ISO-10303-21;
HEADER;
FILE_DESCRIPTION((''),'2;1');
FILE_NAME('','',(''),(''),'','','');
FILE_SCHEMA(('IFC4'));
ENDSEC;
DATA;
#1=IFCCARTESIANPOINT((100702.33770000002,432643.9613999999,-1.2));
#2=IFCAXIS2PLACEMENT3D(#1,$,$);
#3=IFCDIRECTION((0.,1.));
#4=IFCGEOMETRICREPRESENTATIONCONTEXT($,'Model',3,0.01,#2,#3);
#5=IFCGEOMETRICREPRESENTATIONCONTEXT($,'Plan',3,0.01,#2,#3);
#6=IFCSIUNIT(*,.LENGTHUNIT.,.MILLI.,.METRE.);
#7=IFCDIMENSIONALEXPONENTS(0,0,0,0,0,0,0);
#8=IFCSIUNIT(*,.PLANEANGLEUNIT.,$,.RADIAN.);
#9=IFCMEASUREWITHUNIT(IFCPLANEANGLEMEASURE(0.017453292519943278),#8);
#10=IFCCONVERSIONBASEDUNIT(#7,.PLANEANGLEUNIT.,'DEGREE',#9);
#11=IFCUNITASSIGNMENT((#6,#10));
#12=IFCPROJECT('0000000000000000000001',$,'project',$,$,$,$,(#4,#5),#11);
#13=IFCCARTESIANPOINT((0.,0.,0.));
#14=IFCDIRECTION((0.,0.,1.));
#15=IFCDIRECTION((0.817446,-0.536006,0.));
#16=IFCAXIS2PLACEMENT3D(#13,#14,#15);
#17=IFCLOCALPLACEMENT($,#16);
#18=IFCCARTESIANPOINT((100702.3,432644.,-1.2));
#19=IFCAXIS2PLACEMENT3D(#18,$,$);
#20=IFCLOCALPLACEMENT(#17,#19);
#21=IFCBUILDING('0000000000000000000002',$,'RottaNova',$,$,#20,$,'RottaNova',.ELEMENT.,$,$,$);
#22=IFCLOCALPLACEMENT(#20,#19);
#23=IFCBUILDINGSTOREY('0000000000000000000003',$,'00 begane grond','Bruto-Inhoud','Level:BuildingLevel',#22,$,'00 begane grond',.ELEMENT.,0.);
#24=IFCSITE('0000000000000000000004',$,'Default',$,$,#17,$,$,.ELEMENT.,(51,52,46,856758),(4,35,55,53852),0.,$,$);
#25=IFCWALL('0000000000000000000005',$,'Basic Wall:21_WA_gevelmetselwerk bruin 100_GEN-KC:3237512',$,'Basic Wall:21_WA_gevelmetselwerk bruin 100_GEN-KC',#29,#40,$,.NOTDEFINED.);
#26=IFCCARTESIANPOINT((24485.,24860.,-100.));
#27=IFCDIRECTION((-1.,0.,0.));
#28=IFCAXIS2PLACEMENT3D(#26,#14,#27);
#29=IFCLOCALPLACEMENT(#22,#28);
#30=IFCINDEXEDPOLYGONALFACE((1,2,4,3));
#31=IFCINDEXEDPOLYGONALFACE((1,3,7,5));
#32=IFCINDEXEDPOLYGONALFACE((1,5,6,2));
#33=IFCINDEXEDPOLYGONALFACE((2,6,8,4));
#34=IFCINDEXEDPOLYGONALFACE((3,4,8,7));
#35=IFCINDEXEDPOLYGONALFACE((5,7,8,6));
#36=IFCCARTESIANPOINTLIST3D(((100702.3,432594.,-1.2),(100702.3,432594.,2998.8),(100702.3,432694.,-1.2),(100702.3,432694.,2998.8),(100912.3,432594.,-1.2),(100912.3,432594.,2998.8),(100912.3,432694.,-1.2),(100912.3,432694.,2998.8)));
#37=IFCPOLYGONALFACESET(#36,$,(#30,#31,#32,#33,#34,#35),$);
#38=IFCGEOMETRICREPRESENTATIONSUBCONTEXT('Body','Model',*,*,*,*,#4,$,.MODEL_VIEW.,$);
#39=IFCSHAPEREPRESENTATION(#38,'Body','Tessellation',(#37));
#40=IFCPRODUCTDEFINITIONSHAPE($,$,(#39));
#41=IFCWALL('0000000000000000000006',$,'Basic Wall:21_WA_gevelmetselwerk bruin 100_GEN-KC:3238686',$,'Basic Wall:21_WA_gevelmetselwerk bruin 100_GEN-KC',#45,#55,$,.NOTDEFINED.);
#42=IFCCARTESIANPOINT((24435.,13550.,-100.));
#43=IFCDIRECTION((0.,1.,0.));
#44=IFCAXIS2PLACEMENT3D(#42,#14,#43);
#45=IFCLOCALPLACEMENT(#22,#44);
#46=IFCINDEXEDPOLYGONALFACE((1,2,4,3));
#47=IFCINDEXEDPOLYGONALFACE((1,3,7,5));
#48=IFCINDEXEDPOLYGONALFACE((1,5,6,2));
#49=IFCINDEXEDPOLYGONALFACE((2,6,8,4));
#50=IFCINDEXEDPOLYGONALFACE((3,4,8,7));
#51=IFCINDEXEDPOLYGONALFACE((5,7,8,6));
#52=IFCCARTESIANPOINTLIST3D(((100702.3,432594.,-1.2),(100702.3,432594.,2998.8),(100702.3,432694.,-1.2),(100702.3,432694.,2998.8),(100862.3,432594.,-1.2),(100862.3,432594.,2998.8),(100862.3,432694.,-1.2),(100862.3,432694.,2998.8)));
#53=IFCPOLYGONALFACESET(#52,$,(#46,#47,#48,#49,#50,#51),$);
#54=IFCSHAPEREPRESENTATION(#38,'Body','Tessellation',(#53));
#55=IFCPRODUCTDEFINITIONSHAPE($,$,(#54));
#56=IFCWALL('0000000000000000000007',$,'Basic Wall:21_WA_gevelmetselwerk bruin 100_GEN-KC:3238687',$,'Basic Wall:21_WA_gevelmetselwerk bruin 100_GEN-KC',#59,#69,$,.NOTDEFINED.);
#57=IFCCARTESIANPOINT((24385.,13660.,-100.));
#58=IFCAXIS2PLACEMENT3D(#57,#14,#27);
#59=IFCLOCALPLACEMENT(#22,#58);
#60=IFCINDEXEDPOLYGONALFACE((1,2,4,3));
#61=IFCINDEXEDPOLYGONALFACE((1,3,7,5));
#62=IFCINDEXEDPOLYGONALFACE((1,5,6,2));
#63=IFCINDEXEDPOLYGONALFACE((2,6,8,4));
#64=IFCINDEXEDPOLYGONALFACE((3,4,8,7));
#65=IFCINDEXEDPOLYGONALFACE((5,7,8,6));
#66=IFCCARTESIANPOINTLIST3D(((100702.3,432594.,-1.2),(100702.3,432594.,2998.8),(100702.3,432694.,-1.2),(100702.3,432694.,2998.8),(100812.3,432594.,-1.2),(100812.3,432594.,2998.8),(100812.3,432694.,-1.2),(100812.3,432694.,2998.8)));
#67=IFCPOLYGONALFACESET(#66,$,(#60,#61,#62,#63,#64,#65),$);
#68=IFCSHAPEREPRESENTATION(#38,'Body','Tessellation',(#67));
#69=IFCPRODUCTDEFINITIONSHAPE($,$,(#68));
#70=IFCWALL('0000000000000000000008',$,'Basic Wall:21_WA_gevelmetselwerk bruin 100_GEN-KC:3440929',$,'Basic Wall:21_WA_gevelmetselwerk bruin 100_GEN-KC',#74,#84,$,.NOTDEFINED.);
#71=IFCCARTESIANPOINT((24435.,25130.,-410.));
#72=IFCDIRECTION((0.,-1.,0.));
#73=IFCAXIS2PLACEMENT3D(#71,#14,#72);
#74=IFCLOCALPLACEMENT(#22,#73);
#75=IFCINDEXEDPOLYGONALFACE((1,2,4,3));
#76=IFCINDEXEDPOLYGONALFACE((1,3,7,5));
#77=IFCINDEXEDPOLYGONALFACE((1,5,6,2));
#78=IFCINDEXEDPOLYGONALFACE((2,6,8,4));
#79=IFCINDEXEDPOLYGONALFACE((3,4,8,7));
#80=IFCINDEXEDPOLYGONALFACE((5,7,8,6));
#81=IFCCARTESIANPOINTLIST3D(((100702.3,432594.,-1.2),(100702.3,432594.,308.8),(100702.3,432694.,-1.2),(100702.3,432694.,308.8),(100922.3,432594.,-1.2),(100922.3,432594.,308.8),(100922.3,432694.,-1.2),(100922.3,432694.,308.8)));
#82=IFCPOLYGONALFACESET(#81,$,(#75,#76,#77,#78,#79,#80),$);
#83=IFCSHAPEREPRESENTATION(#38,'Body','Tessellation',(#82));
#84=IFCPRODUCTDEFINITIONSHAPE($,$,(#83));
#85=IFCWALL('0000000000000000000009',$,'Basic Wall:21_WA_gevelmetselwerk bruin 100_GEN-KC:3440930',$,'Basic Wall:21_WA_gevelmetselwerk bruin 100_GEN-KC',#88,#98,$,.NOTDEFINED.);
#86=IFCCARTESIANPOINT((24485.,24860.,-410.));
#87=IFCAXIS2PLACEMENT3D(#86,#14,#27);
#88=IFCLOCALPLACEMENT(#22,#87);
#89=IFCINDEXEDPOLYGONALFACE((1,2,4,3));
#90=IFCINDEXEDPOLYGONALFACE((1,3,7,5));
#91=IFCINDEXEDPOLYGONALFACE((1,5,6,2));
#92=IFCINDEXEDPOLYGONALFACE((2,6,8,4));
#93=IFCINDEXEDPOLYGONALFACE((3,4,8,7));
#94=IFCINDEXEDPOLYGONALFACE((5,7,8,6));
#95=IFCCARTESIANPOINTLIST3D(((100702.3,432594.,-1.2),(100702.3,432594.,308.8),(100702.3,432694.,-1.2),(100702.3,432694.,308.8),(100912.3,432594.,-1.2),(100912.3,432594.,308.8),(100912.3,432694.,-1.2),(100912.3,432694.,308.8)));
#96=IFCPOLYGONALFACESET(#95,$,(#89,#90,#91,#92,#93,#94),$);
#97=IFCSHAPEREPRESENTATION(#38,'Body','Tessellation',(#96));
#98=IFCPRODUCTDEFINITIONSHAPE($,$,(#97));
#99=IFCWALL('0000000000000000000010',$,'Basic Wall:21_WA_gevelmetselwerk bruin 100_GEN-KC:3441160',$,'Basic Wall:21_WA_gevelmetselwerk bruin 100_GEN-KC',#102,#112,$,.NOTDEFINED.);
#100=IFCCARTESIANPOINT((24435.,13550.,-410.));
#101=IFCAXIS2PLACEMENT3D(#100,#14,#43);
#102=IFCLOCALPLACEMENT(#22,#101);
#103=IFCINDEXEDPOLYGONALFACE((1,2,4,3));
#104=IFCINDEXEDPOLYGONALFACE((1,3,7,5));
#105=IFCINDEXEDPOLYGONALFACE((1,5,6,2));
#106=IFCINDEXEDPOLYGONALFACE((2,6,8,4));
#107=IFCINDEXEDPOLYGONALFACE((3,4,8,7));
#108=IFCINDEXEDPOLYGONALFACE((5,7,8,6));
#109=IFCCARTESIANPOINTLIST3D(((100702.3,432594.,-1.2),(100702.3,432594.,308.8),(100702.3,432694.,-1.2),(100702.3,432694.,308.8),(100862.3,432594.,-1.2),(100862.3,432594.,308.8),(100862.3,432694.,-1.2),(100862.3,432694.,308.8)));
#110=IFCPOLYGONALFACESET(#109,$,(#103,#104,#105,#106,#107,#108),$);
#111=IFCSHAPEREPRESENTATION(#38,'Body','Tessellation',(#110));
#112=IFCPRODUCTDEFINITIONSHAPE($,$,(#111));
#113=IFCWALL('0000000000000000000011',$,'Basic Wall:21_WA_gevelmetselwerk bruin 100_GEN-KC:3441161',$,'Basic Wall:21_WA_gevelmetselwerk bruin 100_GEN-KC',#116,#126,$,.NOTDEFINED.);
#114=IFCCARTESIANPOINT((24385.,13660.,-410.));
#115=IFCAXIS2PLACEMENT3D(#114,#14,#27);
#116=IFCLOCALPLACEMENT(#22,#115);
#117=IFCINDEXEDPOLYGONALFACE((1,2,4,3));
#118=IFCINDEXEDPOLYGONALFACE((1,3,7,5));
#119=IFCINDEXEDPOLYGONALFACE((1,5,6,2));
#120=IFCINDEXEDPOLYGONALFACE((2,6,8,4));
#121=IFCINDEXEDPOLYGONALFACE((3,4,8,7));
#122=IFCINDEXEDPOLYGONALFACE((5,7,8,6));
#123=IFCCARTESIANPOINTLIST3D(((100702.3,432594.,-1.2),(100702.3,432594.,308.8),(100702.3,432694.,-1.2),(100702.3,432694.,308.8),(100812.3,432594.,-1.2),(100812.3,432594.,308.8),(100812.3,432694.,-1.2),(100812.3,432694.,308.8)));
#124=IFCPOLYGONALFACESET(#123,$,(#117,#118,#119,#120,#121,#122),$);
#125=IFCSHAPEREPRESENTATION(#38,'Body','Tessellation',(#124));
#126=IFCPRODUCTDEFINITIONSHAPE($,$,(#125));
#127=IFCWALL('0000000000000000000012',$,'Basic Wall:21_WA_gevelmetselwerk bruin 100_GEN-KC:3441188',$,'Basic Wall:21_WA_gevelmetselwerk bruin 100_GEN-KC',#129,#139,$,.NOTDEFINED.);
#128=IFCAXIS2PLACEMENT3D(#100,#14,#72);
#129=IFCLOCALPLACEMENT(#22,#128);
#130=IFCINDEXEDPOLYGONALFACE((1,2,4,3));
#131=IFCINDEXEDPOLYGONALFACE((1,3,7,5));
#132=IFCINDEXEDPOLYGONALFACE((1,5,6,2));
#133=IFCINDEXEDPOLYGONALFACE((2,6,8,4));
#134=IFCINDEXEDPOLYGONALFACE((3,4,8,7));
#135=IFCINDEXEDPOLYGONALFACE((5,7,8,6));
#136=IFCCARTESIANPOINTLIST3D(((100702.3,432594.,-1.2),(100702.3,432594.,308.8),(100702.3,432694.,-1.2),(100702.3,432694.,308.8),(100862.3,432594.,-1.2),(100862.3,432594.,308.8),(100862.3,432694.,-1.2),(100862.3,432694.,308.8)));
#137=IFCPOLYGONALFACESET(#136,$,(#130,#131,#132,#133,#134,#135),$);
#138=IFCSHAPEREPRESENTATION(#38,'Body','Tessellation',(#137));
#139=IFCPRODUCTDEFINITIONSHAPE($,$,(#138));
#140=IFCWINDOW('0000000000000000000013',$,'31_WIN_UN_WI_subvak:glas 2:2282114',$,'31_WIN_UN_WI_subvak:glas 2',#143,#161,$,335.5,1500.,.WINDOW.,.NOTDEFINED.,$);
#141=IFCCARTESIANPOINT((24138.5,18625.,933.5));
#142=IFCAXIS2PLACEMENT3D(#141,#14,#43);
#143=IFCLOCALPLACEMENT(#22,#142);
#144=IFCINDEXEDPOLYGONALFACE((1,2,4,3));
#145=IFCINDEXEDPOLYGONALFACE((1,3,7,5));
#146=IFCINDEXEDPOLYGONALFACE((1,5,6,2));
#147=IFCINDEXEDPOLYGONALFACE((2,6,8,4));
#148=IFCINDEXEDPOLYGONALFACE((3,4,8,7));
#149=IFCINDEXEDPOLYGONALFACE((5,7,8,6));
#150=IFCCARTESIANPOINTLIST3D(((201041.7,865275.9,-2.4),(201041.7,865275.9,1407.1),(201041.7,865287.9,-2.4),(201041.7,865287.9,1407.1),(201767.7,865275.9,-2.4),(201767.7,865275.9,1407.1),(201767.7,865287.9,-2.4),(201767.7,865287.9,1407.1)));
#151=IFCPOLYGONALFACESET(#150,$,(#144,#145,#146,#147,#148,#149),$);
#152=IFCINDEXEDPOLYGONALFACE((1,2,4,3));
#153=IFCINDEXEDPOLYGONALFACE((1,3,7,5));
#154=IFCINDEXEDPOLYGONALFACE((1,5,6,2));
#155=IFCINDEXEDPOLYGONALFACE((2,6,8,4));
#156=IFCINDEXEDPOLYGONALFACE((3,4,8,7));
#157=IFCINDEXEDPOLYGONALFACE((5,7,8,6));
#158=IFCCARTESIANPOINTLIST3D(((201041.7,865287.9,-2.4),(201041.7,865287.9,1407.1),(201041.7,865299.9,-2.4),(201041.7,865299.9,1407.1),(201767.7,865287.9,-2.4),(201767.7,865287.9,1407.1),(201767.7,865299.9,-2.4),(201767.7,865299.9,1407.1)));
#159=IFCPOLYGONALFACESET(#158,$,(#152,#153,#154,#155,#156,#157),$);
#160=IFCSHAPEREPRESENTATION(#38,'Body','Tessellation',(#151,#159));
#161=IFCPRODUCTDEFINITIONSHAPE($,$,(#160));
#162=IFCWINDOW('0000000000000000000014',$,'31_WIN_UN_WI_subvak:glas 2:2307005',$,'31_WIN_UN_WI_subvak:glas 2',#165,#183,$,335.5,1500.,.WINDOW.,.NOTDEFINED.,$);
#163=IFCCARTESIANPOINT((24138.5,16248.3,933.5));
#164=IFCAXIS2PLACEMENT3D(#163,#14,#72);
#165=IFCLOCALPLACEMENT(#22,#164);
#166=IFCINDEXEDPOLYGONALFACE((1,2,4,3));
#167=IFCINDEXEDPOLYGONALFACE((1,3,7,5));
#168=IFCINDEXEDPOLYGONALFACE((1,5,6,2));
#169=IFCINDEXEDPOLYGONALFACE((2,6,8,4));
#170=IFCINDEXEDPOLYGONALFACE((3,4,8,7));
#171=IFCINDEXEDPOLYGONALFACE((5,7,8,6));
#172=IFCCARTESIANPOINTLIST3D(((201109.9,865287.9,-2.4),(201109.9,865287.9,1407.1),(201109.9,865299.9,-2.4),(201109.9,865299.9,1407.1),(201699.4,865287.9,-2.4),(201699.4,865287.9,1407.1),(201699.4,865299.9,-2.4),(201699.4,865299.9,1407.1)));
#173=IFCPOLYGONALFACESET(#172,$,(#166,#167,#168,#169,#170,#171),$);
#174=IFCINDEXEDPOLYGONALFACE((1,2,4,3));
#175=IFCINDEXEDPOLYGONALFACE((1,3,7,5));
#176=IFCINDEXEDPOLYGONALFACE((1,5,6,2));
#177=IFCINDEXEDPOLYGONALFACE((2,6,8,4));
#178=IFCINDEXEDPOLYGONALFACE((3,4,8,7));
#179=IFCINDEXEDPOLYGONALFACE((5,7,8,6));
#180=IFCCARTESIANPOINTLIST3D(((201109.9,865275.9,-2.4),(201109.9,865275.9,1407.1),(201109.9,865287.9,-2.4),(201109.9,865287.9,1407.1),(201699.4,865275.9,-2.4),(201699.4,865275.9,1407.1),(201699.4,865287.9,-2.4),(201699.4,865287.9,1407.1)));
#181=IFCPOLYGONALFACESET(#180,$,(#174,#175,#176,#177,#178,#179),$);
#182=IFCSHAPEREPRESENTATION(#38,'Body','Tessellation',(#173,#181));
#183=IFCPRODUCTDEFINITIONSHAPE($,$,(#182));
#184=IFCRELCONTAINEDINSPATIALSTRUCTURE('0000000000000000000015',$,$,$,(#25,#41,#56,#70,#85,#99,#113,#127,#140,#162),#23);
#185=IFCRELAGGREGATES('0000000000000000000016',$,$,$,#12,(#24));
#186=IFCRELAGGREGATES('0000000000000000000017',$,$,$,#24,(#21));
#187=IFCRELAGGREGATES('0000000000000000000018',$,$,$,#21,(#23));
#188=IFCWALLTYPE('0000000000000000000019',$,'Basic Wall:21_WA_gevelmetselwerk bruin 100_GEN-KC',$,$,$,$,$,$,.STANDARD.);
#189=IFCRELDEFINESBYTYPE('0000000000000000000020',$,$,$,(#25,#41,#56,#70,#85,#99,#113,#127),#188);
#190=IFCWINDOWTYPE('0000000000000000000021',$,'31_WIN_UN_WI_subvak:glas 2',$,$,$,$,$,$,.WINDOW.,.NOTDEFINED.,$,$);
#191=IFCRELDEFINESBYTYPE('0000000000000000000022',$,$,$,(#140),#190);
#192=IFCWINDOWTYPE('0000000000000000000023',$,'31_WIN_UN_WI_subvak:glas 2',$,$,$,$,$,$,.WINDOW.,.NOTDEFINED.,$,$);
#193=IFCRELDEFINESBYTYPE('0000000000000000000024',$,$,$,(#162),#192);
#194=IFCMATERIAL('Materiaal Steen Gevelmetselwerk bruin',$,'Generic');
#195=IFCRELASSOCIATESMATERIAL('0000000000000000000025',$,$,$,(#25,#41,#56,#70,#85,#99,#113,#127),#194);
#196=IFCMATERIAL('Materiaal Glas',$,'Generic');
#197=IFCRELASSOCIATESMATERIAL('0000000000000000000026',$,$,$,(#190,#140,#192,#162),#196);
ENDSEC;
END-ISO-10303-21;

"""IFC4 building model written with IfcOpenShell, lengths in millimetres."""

from ifc_helpers import new_model, entity, si_unit, converted_unit, direction, frame, place, context, subcontext, project, spatial, indexed_curve, outline, extrude, source, transform, mapped, material, type_object, type_shapes, element, save


model = new_model("IFC4")

# Units and contexts
model_context = context("Model", 3, precision=0.01, world=frame((100702.33770000002, 432643.9613999999, -1.2)), true_north=direction((0.0, 1.0)))
plan_context = context("Plan", 3, precision=0.01, world=frame((100702.33770000002, 432643.9613999999, -1.2)), true_north=direction((0.0, 1.0)))
body_context = subcontext(model_context, "Body", "Model", "MODEL_VIEW")
ifc_project = project(units=[si_unit("LENGTHUNIT", "METRE", prefix="MILLI"), converted_unit("PLANEANGLEUNIT", "DEGREE", entity("IfcPlaneAngleMeasure", 0.017453292519943278), si_unit("PLANEANGLEUNIT", "RADIAN"), dimensions=[0, 0, 0, 0, 0, 0, 0])], contexts=[model_context, plan_context])

# Site, building, storey
site_placement = place(None, frame((0.0, 0.0, 0.0), z_axis=(0.0, 0.0, 1.0), x_axis=(0.817446, -0.536006, 0.0)))
site = spatial("IfcSite", under=ifc_project, at=site_placement, Name="Default", CompositionType="ELEMENT", RefLatitude=(51, 52, 46, 856758), RefLongitude=(4, 35, 55, 53852), RefElevation=0.0)
building_placement = place(site_placement, frame((100702.3, 432644.0, -1.2)))
building = spatial("IfcBuilding", under=site, at=building_placement, Name="RottaNova", LongName="RottaNova", CompositionType="ELEMENT")
storey_placement = place(building_placement, frame((100702.3, 432644.0, -1.2)))
storey = spatial("IfcBuildingStorey", under=building, at=storey_placement, Name="00 begane grond", Description="Bruto-Inhoud", ObjectType="Level:BuildingLevel", LongName="00 begane grond", CompositionType="ELEMENT", Elevation=0.0)

# Walls
ifc_material_1 = material(Name="Materiaal Steen Gevelmetselwerk bruin", Category="Generic")
wall_type_1 = type_object("IfcWallType", Name="Basic Wall:21_WA_gevelmetselwerk bruin 100_GEN-KC", PredefinedType="STANDARD")
wall_1_placement = place(storey_placement, frame((24485.0, 24860.0, -100.0), z_axis=(0.0, 0.0, 1.0), x_axis=(-1.0, 0.0, 0.0)))
element("IfcWall", 1, at=wall_1_placement, inside=storey, type_object=wall_type_1, material=ifc_material_1, Name="Basic Wall:21_WA_gevelmetselwerk bruin 100_GEN-KC:3237512", ObjectType="Basic Wall:21_WA_gevelmetselwerk bruin 100_GEN-KC", PredefinedType="NOTDEFINED", context=body_context, shape_type="SweptSolid", body=[
    extrude(outline(indexed_curve([(210.0, 50.0), (0.0, 50.0), (0.0, -50.0), (210.0, -50.0), (210.0, 50.0)], self_intersect=False)), frame((100702.3, 432644.0, -1.2)), (0.0, 0.0, 1.0), 3000.0),
])
wall_2_placement = place(storey_placement, frame((24435.0, 13550.0, -100.0), z_axis=(0.0, 0.0, 1.0), x_axis=(0.0, 1.0, 0.0)))
element("IfcWall", 2, at=wall_2_placement, inside=storey, type_object=wall_type_1, material=ifc_material_1, Name="Basic Wall:21_WA_gevelmetselwerk bruin 100_GEN-KC:3238686", ObjectType="Basic Wall:21_WA_gevelmetselwerk bruin 100_GEN-KC", PredefinedType="NOTDEFINED", context=body_context, shape_type="SweptSolid", body=[
    extrude(outline(indexed_curve([(160.0, 50.0), (0.0, 50.0), (0.0, -50.0), (160.0, -50.0), (160.0, 50.0)], self_intersect=False)), frame((100702.3, 432644.0, -1.2)), (0.0, 0.0, 1.0), 3000.0),
])
wall_3_placement = place(storey_placement, frame((24385.0, 13660.0, -100.0), z_axis=(0.0, 0.0, 1.0), x_axis=(-1.0, 0.0, 0.0)))
element("IfcWall", 3, at=wall_3_placement, inside=storey, type_object=wall_type_1, material=ifc_material_1, Name="Basic Wall:21_WA_gevelmetselwerk bruin 100_GEN-KC:3238687", ObjectType="Basic Wall:21_WA_gevelmetselwerk bruin 100_GEN-KC", PredefinedType="NOTDEFINED", context=body_context, shape_type="SweptSolid", body=[
    extrude(outline(indexed_curve([(110.0, 50.0), (0.0, 50.0), (0.0, -50.0), (110.0, -50.0), (110.0, 50.0)], self_intersect=False)), frame((100702.3, 432644.0, -1.2)), (0.0, 0.0, 1.0), 3000.0),
])
wall_4_placement = place(storey_placement, frame((24435.0, 25130.0, -410.0), z_axis=(0.0, 0.0, 1.0), x_axis=(0.0, -1.0, 0.0)))
element("IfcWall", 4, at=wall_4_placement, inside=storey, type_object=wall_type_1, material=ifc_material_1, Name="Basic Wall:21_WA_gevelmetselwerk bruin 100_GEN-KC:3440929", ObjectType="Basic Wall:21_WA_gevelmetselwerk bruin 100_GEN-KC", PredefinedType="NOTDEFINED", context=body_context, shape_type="SweptSolid", body=[
    extrude(outline(indexed_curve([(220.0, 50.0), (0.0, 50.0), (0.0, -50.0), (220.0, -50.0), (220.0, 50.0)], self_intersect=False)), frame((100702.3, 432644.0, -1.2)), (0.0, 0.0, 1.0), 310.0),
])
wall_5_placement = place(storey_placement, frame((24485.0, 24860.0, -410.0), z_axis=(0.0, 0.0, 1.0), x_axis=(-1.0, 0.0, 0.0)))
element("IfcWall", 5, at=wall_5_placement, inside=storey, type_object=wall_type_1, material=ifc_material_1, Name="Basic Wall:21_WA_gevelmetselwerk bruin 100_GEN-KC:3440930", ObjectType="Basic Wall:21_WA_gevelmetselwerk bruin 100_GEN-KC", PredefinedType="NOTDEFINED", context=body_context, shape_type="SweptSolid", body=[
    extrude(outline(indexed_curve([(210.0, 50.0), (0.0, 50.0), (0.0, -50.0), (210.0, -50.0), (210.0, 50.0)], self_intersect=False)), frame((100702.3, 432644.0, -1.2)), (0.0, 0.0, 1.0), 310.0),
])
wall_6_placement = place(storey_placement, frame((24435.0, 13550.0, -410.0), z_axis=(0.0, 0.0, 1.0), x_axis=(0.0, 1.0, 0.0)))
element("IfcWall", 6, at=wall_6_placement, inside=storey, type_object=wall_type_1, material=ifc_material_1, Name="Basic Wall:21_WA_gevelmetselwerk bruin 100_GEN-KC:3441160", ObjectType="Basic Wall:21_WA_gevelmetselwerk bruin 100_GEN-KC", PredefinedType="NOTDEFINED", context=body_context, shape_type="SweptSolid", body=[
    extrude(outline(indexed_curve([(160.0, 50.0), (0.0, 50.0), (0.0, -50.0), (160.0, -50.0), (160.0, 50.0)], self_intersect=False)), frame((100702.3, 432644.0, -1.2)), (0.0, 0.0, 1.0), 310.0),
])
wall_7_placement = place(storey_placement, frame((24385.0, 13660.0, -410.0), z_axis=(0.0, 0.0, 1.0), x_axis=(-1.0, 0.0, 0.0)))
element("IfcWall", 7, at=wall_7_placement, inside=storey, type_object=wall_type_1, material=ifc_material_1, Name="Basic Wall:21_WA_gevelmetselwerk bruin 100_GEN-KC:3441161", ObjectType="Basic Wall:21_WA_gevelmetselwerk bruin 100_GEN-KC", PredefinedType="NOTDEFINED", context=body_context, shape_type="SweptSolid", body=[
    extrude(outline(indexed_curve([(110.0, 50.0), (0.0, 50.0), (0.0, -50.0), (110.0, -50.0), (110.0, 50.0)], self_intersect=False)), frame((100702.3, 432644.0, -1.2)), (0.0, 0.0, 1.0), 310.0),
])
wall_8_placement = place(storey_placement, frame((24435.0, 13550.0, -410.0), z_axis=(0.0, 0.0, 1.0), x_axis=(0.0, -1.0, 0.0)))
element("IfcWall", 8, at=wall_8_placement, inside=storey, type_object=wall_type_1, material=ifc_material_1, Name="Basic Wall:21_WA_gevelmetselwerk bruin 100_GEN-KC:3441188", ObjectType="Basic Wall:21_WA_gevelmetselwerk bruin 100_GEN-KC", PredefinedType="NOTDEFINED", context=body_context, shape_type="SweptSolid", body=[
    extrude(outline(indexed_curve([(160.0, 50.0), (0.0, 50.0), (0.0, -50.0), (160.0, -50.0), (160.0, 50.0)], self_intersect=False)), frame((100702.3, 432644.0, -1.2)), (0.0, 0.0, 1.0), 310.0),
])

# Windows
ifc_material_2 = material(Name="Materiaal Glas", Category="Generic")
window_type_1 = type_object("IfcWindowType", Name="31_WIN_UN_WI_subvak:glas 2", PartitioningType="NOTDEFINED", PredefinedType="WINDOW", material=ifc_material_2)
shared_shape_1 = source(frame((100702.3, 432644.0, -1.2)), body_context, "Body", "SweptSolid", [
    extrude(outline(indexed_curve([(-363.0, -6.0), (363.0, -6.0), (363.0, 6.0), (-363.0, 6.0), (-363.0, -6.0)], self_intersect=False)), frame((0.0, -6.0, 0.0)), (0.0, 0.0, 1.0), 1409.5),
    extrude(outline(indexed_curve([(-363.0, -6.0), (363.0, -6.0), (363.0, 6.0), (-363.0, 6.0), (-363.0, -6.0)], self_intersect=False)), frame((0.0, 6.0, 0.0)), (0.0, 0.0, 1.0), 1409.5),
])
type_shapes(window_type_1, [shared_shape_1])
window_placement = place(storey_placement, frame((24138.5, 18625.0, 933.5), z_axis=(0.0, 0.0, 1.0), x_axis=(0.0, 1.0, 0.0)))
element("IfcWindow", 9, at=window_placement, inside=storey, type_object=window_type_1, material=ifc_material_2, Name="31_WIN_UN_WI_subvak:glas 2:2282114", ObjectType="31_WIN_UN_WI_subvak:glas 2", OverallHeight=335.5, OverallWidth=1500.0, PartitioningType="NOTDEFINED", PredefinedType="WINDOW", context=body_context, shape_type="MappedRepresentation", body=[
    mapped(shared_shape_1, transform((100702.3, 432644.0, -1.2), scale=1.0)),
])
window_type_2 = type_object("IfcWindowType", Name="31_WIN_UN_WI_subvak:glas 2", PartitioningType="NOTDEFINED", PredefinedType="WINDOW", material=ifc_material_2)
shared_shape_2 = source(frame((100702.3, 432644.0, -1.2)), body_context, "Body", "SweptSolid", [
    extrude(outline(indexed_curve([(-6.0, -294.7), (6.0, -294.7), (6.0, 294.7), (-6.0, 294.7), (-6.0, -294.7)], self_intersect=False)), frame((0.0, 6.0, 0.0), z_axis=(0.0, 0.0, 1.0), x_axis=(0.0, -1.0, 0.0)), (0.0, 0.0, 1.0), 1409.5),
    extrude(outline(indexed_curve([(-6.0, -294.8), (6.0, -294.8), (6.0, 294.8), (-6.0, 294.8), (-6.0, -294.8)], self_intersect=False)), frame((0.0, -6.0, 0.0), z_axis=(0.0, 0.0, 1.0), x_axis=(0.0, -1.0, 0.0)), (0.0, 0.0, 1.0), 1409.5),
])
type_shapes(window_type_2, [shared_shape_2])
for number, where, z_axis, x_axis, name in (
    (10, (24138.5, 16248.3, 933.5), (0.0, 0.0, 1.0), (0.0, -1.0, 0.0), "31_WIN_UN_WI_subvak:glas 2:2307005"),
):
    element("IfcWindow", number, at=place(storey_placement, frame(where, z_axis=z_axis, x_axis=x_axis)), inside=storey, type_object=window_type_2, material=ifc_material_2, Name=name, ObjectType="31_WIN_UN_WI_subvak:glas 2", OverallHeight=335.5, OverallWidth=1500.0, PartitioningType="NOTDEFINED", PredefinedType="WINDOW", context=body_context, shape_type="MappedRepresentation", body=[
        mapped(shared_shape_2, transform((100702.3, 432644.0, -1.2), scale=1.0)),
    ])

save(model, "model.ifc")
